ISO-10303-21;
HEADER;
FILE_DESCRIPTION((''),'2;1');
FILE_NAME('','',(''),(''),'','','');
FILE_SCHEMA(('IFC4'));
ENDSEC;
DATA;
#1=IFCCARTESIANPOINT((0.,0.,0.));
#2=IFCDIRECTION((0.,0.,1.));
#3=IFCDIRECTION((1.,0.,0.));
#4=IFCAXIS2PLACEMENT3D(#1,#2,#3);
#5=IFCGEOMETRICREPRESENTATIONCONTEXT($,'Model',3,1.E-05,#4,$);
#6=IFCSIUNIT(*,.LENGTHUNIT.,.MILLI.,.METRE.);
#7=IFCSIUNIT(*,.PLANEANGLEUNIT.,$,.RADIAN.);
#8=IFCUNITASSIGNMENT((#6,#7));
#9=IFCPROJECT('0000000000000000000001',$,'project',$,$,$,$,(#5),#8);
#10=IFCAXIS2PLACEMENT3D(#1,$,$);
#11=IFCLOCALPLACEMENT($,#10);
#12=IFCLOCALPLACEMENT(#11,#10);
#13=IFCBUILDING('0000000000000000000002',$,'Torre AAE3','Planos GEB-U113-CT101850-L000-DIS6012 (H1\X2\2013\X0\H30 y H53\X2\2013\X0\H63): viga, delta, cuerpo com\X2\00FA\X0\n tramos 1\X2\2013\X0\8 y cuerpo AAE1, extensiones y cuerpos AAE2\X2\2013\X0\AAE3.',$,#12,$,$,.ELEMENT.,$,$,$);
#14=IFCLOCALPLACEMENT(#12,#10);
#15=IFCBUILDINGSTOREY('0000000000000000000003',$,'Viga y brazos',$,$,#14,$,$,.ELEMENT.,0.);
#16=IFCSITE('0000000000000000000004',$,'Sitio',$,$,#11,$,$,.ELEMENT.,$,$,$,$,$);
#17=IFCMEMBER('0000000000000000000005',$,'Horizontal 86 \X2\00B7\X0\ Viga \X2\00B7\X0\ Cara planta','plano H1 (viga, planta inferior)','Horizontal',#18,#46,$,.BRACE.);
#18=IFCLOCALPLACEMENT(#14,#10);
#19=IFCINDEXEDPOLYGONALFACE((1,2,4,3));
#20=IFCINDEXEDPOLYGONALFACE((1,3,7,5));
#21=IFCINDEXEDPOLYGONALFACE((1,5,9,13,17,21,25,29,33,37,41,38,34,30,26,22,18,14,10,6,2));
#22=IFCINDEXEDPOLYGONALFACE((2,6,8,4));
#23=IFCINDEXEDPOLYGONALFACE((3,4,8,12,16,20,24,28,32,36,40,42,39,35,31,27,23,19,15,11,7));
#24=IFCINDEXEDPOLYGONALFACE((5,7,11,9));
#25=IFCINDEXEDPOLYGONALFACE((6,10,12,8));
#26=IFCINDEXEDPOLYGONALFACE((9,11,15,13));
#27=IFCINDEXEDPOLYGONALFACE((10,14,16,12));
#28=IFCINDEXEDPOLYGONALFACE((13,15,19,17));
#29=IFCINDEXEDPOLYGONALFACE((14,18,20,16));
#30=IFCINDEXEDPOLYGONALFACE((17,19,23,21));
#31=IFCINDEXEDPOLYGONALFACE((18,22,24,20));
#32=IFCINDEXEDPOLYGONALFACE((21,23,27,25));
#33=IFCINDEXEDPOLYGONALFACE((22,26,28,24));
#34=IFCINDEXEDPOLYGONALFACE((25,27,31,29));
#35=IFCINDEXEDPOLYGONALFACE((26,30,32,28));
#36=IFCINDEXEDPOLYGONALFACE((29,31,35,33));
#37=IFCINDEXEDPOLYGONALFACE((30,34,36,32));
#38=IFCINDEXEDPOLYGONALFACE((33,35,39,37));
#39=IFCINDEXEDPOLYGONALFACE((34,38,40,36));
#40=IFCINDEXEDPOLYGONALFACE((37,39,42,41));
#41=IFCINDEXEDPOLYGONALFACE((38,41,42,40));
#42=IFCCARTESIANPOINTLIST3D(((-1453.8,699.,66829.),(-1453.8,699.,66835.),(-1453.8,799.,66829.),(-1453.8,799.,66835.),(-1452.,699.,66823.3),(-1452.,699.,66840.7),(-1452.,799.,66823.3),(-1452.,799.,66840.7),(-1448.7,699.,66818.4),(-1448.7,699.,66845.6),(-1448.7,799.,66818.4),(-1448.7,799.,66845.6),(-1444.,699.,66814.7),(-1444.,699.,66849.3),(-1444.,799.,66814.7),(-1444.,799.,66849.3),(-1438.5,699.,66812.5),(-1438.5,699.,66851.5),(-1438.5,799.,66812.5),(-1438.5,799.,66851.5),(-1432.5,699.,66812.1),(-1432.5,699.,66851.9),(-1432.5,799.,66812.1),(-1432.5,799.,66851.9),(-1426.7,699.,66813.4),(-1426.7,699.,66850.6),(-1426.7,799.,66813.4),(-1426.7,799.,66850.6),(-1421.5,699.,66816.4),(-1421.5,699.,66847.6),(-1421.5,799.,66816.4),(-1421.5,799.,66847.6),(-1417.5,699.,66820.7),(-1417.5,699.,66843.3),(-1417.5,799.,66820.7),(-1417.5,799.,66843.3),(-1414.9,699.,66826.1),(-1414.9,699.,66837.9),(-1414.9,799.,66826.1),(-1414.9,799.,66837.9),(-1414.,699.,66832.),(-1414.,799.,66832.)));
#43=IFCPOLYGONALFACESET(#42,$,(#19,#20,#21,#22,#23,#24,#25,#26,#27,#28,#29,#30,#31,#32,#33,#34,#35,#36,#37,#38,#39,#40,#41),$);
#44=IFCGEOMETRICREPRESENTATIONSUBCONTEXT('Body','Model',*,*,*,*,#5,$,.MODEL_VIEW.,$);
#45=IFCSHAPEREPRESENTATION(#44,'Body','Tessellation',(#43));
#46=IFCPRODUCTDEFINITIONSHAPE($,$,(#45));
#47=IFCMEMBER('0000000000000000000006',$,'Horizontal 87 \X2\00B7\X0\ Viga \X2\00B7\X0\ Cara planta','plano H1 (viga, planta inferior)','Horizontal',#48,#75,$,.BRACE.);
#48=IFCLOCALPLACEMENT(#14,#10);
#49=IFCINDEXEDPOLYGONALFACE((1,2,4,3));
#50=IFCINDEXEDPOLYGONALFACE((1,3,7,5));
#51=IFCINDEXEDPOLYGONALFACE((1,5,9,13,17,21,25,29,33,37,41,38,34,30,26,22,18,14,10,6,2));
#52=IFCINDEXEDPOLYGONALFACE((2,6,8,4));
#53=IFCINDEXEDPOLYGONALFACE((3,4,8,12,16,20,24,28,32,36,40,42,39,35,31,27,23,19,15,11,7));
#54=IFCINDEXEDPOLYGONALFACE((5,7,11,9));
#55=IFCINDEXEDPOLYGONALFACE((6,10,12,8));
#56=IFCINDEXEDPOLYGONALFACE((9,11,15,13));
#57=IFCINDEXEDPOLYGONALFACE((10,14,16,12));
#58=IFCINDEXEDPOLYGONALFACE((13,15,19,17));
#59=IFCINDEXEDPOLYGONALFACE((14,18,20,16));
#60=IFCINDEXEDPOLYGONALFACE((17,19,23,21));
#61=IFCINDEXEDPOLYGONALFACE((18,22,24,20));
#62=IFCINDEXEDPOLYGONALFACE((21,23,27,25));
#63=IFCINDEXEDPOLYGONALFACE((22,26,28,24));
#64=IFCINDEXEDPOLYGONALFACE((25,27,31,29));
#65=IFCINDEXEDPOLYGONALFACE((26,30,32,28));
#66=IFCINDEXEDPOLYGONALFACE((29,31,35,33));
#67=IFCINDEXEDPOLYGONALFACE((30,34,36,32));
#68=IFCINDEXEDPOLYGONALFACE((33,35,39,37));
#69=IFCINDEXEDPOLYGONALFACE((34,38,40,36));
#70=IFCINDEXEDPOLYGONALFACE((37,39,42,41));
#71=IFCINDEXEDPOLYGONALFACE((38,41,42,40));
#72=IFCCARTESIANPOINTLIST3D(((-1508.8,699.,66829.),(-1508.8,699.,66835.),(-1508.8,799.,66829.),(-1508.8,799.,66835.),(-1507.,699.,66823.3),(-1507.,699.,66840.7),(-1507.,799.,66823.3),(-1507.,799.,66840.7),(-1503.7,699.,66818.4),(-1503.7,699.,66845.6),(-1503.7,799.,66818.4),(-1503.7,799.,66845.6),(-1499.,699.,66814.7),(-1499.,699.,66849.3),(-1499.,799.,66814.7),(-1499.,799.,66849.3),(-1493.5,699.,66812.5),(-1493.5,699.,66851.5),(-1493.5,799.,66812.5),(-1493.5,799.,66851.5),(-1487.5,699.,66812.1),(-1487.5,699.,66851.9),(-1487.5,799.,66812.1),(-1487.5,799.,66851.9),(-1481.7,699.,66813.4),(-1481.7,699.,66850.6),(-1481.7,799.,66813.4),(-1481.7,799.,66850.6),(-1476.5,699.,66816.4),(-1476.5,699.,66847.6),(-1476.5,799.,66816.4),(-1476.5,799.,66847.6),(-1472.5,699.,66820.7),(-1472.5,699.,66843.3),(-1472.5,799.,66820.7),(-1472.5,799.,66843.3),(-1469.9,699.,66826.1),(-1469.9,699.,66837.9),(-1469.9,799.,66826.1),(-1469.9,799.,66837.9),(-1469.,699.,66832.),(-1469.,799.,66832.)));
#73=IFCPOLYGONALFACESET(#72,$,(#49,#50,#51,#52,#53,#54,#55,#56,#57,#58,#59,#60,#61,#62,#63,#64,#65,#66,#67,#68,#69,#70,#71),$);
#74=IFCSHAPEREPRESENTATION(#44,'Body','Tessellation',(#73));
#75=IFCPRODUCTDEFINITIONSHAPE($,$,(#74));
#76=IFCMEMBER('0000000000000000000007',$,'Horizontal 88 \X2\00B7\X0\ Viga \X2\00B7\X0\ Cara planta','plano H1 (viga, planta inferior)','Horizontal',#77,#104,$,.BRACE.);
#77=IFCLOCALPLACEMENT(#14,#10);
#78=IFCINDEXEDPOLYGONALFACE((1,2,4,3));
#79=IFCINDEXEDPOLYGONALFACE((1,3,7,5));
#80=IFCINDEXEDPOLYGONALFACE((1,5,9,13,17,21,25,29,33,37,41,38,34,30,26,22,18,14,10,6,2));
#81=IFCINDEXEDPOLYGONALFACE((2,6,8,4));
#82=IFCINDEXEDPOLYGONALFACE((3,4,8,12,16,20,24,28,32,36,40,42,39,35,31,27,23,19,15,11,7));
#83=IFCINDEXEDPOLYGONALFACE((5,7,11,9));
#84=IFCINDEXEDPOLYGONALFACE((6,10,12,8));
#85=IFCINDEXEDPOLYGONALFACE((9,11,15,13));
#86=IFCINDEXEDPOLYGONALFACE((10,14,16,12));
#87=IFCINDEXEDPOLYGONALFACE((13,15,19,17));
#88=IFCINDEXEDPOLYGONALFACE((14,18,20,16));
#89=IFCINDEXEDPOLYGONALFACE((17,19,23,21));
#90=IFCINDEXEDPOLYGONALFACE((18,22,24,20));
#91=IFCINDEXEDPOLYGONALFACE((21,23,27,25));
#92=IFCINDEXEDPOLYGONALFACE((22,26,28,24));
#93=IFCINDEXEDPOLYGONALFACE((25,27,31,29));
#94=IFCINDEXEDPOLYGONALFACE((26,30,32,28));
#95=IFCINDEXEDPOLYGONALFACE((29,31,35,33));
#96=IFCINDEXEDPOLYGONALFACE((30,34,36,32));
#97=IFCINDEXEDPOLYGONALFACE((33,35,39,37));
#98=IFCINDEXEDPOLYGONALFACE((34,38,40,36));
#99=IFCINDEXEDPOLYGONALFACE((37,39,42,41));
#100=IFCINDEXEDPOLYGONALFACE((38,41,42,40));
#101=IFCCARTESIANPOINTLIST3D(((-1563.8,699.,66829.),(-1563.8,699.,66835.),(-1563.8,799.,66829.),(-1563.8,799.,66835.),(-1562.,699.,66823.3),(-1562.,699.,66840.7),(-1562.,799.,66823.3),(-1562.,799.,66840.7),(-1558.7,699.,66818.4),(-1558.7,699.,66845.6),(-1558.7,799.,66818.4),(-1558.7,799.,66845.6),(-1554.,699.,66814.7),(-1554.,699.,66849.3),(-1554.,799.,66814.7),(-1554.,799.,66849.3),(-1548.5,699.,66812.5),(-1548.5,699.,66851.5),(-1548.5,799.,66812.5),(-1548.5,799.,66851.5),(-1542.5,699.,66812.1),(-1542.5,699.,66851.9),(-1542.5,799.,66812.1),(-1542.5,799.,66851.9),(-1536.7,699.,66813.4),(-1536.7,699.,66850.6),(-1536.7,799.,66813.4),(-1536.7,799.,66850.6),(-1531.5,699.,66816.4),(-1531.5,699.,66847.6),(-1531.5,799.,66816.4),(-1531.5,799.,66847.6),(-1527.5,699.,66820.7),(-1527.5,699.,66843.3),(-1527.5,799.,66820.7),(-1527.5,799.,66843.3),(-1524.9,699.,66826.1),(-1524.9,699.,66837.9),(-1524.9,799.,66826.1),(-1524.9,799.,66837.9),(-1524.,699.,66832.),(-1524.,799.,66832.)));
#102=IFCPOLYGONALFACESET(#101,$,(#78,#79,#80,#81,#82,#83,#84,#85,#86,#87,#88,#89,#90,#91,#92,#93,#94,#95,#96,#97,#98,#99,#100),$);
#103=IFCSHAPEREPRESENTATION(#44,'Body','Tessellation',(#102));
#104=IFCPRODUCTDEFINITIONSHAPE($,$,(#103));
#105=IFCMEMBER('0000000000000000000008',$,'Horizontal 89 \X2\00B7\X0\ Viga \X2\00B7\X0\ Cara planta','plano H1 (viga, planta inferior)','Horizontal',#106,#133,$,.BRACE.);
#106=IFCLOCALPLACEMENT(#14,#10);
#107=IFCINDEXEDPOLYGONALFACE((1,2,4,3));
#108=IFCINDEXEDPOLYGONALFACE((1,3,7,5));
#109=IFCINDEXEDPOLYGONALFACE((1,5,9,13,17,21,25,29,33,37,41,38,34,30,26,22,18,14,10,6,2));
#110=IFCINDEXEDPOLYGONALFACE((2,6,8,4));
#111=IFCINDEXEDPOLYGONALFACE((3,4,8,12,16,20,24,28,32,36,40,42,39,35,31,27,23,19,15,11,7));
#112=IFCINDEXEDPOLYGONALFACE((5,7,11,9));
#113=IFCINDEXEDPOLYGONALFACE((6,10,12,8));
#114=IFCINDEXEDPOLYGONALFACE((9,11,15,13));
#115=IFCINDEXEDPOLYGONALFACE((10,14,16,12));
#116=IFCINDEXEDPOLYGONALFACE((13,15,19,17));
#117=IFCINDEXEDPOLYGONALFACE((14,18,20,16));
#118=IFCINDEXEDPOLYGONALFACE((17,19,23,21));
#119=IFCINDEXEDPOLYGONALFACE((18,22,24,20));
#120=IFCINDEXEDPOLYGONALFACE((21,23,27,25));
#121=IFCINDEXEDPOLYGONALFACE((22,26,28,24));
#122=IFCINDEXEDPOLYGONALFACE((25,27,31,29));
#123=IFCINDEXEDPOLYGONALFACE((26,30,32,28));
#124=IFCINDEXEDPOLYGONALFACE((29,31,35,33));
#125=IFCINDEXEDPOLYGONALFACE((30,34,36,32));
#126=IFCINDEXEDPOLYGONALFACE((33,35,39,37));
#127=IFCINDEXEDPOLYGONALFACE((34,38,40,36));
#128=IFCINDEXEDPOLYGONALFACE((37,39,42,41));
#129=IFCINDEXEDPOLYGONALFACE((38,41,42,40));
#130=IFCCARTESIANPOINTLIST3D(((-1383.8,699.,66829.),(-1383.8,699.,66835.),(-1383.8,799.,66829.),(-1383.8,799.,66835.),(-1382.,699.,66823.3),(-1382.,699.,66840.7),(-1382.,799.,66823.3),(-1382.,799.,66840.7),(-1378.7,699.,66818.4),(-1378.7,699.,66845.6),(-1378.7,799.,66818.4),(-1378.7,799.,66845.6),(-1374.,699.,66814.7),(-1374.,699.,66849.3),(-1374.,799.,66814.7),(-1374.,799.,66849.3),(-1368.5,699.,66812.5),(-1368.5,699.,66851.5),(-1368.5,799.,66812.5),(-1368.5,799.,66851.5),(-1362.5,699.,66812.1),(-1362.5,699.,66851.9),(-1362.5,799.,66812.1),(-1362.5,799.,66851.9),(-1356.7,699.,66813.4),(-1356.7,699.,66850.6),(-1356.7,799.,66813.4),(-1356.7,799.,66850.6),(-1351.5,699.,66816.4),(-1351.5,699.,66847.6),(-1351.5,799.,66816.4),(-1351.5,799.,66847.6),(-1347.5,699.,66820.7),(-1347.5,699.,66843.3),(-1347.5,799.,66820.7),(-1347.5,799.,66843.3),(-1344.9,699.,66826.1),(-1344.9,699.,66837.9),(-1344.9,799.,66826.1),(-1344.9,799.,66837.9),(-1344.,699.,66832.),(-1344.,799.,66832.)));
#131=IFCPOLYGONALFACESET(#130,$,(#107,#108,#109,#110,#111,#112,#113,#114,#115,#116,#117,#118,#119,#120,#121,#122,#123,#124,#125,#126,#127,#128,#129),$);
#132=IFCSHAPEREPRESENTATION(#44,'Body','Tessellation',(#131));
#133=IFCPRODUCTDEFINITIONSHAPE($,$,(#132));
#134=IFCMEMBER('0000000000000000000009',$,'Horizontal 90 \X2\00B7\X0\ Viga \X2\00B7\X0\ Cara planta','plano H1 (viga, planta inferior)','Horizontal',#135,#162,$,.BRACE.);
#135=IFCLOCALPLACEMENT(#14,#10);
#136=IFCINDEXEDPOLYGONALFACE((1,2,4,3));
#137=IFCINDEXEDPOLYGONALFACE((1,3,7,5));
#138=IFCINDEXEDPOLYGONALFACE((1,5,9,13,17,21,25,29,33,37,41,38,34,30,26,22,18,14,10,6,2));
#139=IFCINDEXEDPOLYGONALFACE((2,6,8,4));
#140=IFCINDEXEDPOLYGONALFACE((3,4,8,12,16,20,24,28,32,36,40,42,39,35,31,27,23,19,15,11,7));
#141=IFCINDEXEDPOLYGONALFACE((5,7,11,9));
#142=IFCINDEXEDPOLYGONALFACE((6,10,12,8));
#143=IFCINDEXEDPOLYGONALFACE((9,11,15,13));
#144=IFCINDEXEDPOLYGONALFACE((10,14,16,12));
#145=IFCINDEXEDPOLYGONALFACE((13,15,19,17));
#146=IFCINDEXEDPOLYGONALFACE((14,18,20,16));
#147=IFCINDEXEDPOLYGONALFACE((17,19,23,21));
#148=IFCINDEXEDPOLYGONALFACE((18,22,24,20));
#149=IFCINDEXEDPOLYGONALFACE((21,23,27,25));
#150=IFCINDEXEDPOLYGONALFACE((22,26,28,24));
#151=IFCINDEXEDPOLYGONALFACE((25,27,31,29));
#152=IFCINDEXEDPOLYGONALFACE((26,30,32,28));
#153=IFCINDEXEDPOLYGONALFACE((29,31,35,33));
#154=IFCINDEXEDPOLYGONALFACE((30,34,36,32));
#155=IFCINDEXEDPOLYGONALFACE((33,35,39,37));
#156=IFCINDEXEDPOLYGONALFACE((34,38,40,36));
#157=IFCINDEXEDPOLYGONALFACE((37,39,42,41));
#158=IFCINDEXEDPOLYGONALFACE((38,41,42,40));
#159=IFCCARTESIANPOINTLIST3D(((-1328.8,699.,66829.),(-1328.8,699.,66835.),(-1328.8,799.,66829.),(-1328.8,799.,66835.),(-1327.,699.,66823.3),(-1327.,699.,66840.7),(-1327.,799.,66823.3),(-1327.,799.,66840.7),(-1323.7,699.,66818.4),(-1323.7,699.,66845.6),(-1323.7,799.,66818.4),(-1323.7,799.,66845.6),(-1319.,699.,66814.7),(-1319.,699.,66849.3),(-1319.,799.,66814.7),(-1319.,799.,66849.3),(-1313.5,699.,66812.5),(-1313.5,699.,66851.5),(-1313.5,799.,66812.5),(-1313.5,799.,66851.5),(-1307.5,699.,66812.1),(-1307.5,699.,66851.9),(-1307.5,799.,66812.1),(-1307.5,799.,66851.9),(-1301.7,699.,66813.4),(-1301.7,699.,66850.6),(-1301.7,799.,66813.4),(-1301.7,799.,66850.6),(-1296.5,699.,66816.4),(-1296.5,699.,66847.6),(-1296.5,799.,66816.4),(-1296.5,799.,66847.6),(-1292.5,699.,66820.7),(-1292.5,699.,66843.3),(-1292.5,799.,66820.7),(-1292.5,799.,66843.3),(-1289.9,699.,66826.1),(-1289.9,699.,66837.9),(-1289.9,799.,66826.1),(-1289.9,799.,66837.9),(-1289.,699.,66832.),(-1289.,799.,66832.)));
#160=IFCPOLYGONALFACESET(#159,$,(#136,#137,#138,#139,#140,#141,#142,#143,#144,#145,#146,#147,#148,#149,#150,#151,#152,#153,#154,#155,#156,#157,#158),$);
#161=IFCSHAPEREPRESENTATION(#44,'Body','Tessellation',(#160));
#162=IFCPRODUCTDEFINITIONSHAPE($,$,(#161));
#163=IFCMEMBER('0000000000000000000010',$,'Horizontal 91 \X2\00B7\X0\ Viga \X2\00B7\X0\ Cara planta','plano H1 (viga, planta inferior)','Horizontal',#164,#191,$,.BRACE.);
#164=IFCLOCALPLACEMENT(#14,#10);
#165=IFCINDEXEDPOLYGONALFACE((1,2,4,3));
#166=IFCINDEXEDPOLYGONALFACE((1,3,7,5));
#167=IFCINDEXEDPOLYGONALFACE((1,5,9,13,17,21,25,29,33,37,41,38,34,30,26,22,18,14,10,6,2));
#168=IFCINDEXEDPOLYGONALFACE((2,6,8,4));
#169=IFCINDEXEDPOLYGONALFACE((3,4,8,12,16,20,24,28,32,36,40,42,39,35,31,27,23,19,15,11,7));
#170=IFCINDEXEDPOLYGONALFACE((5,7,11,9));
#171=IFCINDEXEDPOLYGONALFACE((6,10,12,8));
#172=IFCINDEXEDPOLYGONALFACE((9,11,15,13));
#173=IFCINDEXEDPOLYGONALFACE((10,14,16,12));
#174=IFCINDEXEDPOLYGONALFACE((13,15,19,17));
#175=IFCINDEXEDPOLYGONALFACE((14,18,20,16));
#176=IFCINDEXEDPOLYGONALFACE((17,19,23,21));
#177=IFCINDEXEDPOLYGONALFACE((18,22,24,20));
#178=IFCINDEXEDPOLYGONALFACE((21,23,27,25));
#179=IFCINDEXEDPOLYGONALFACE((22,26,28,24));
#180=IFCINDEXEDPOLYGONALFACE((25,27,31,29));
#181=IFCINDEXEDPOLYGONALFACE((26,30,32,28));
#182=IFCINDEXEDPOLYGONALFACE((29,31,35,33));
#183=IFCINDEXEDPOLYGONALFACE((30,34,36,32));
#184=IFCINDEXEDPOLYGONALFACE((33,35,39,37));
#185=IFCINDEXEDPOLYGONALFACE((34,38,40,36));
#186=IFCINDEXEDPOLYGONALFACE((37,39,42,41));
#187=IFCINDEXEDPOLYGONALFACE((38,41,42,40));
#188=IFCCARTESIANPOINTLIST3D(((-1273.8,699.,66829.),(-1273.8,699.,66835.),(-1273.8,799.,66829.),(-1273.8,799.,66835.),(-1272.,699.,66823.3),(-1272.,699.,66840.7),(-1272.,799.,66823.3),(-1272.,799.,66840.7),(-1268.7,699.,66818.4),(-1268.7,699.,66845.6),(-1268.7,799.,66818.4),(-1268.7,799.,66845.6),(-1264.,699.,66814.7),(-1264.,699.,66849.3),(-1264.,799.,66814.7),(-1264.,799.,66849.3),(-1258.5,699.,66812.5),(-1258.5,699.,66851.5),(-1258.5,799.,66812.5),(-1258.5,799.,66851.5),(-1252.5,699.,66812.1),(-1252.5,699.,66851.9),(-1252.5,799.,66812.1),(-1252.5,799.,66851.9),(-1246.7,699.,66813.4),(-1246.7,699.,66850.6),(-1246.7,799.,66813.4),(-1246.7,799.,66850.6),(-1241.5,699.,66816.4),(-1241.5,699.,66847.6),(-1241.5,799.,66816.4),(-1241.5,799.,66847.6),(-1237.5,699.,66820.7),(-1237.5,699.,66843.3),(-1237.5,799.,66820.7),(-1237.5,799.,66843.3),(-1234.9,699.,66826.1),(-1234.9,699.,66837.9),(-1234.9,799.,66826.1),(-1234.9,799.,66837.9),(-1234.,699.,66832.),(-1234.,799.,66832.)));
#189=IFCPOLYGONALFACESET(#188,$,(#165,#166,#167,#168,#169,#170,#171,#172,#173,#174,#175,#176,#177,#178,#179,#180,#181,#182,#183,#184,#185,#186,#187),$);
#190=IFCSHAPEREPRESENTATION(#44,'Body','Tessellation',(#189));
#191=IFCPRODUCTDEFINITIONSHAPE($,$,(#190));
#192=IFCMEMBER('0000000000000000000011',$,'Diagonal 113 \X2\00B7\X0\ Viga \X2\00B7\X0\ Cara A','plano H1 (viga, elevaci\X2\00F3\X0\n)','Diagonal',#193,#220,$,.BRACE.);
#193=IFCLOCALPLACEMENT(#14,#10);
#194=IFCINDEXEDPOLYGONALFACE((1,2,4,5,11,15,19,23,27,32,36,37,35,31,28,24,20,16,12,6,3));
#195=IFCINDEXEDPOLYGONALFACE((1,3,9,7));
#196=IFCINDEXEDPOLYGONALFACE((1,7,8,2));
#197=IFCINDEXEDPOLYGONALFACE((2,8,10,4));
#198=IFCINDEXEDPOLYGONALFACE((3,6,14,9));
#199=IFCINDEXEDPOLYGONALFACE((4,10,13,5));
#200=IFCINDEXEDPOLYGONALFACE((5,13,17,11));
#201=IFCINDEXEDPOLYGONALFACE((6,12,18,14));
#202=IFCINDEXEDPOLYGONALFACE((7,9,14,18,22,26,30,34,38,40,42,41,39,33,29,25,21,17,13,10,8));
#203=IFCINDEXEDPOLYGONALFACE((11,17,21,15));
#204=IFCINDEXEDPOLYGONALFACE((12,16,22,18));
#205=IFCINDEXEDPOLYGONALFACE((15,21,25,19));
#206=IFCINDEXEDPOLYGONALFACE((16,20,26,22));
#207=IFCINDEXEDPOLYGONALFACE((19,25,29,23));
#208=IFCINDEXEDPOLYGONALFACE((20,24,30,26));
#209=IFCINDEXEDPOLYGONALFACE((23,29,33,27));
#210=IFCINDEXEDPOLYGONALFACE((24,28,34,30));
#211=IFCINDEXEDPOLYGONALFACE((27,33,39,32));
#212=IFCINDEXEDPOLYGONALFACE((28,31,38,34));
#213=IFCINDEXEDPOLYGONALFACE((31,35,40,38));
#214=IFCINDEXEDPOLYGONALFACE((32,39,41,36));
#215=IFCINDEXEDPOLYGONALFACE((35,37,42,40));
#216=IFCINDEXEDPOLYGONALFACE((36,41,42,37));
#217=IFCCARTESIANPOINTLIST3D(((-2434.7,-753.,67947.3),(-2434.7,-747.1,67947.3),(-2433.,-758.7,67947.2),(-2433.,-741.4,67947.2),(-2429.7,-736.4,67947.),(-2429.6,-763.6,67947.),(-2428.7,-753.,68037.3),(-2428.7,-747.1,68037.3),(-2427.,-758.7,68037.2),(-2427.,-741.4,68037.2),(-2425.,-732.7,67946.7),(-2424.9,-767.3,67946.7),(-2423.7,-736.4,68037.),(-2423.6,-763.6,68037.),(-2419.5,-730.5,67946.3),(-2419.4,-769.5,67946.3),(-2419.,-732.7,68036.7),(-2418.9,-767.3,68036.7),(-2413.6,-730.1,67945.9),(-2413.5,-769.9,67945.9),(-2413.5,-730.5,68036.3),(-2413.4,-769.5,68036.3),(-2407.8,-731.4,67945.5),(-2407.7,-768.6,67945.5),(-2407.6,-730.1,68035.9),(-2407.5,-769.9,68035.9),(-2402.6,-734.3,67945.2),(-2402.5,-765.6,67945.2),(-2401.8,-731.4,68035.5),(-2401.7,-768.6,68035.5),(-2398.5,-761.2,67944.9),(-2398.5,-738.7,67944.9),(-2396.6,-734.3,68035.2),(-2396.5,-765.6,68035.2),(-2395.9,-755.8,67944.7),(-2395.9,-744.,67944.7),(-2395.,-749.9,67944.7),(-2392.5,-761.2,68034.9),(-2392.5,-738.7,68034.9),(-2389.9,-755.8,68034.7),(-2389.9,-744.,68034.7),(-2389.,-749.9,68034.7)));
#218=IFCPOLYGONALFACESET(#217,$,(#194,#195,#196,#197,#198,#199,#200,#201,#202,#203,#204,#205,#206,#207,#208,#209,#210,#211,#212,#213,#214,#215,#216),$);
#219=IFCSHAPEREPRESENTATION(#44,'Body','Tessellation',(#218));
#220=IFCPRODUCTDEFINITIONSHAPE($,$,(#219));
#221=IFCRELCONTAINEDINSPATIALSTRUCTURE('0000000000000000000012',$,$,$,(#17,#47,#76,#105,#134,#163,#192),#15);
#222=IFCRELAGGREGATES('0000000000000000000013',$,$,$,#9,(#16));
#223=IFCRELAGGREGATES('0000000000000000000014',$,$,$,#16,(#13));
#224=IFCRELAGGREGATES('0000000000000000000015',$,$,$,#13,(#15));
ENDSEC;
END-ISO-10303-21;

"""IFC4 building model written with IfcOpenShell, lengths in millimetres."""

from ifc_helpers import new_model, si_unit, frame, origin, origin_with_axes, place, context, subcontext, project, spatial, circle, extrude, element, save


model = new_model("IFC4")

# Units and contexts
model_context = context("Model", 3, precision=1e-05, world=origin_with_axes())
body_context = subcontext(model_context, "Body", "Model", "MODEL_VIEW")
ifc_project = project(units=[si_unit("LENGTHUNIT", "METRE", prefix="MILLI"), si_unit("PLANEANGLEUNIT", "RADIAN")], contexts=[model_context])

# Site, building, storey
site_placement = place(None, origin())
site = spatial("IfcSite", under=ifc_project, at=site_placement, Name="Sitio", CompositionType="ELEMENT")
building_placement = place(site_placement, origin())
building = spatial("IfcBuilding", under=site, at=building_placement, Name="Torre AAE3", Description="Planos GEB-U113-CT101850-L000-DIS6012 (H1–H30 y H53–H63): viga, delta, cuerpo común tramos 1–8 y cuerpo AAE1, extensiones y cuerpos AAE2–AAE3.", CompositionType="ELEMENT")
storey_placement = place(building_placement, origin())
storey = spatial("IfcBuildingStorey", under=building, at=storey_placement, Name="Viga y brazos", CompositionType="ELEMENT", Elevation=0.0)

# Members
for number, where, z_axis, x_axis, name in (
    (1, (-1434.0, 699.0, 66832.0), (0.0, 1.0, 0.0), (1.0, 0.0, 0.0), "Horizontal 86 · Viga · Cara planta"),
    (2, (-1489.0, 699.0, 66832.0), (0.0, 1.0, 0.0), (1.0, 0.0, 0.0), "Horizontal 87 · Viga · Cara planta"),
    (3, (-1544.0, 699.0, 66832.0), (0.0, 1.0, 0.0), (1.0, 0.0, 0.0), "Horizontal 88 · Viga · Cara planta"),
    (4, (-1364.0, 699.0, 66832.0), (0.0, 1.0, 0.0), (1.0, 0.0, 0.0), "Horizontal 89 · Viga · Cara planta"),
    (5, (-1309.0, 699.0, 66832.0), (0.0, 1.0, 0.0), (1.0, 0.0, 0.0), "Horizontal 90 · Viga · Cara planta"),
    (6, (-1254.0, 699.0, 66832.0), (0.0, 1.0, 0.0), (1.0, 0.0, 0.0), "Horizontal 91 · Viga · Cara planta"),
):
    element("IfcMember", number, at=place(storey_placement, frame(where, z_axis=z_axis, x_axis=x_axis)), inside=storey, Name=name, Description="plano H1 (viga, planta inferior)", ObjectType="Horizontal", PredefinedType="BRACE", context=body_context, shape_type="SweptSolid", body=[
        extrude(circle(Radius=20.0), None, (0.0, 0.0, 1.0), 100.0),
    ])
for number, where, z_axis, x_axis, name in (
    (7, (-2415.0, -750.0, 67946.0), (0.066519, 0.0, 0.997785), (0.9526, 0.297523, -0.063507), "Diagonal 113 · Viga · Cara A"),
):
    element("IfcMember", number, at=place(storey_placement, frame(where, z_axis=z_axis, x_axis=x_axis)), inside=storey, Name=name, Description="plano H1 (viga, elevación)", ObjectType="Diagonal", PredefinedType="BRACE", context=body_context, shape_type="SweptSolid", body=[
        extrude(circle(Radius=20.0), None, (0.0, 0.0, 1.0), 90.2),
    ])

save(model, "model.ifc")
